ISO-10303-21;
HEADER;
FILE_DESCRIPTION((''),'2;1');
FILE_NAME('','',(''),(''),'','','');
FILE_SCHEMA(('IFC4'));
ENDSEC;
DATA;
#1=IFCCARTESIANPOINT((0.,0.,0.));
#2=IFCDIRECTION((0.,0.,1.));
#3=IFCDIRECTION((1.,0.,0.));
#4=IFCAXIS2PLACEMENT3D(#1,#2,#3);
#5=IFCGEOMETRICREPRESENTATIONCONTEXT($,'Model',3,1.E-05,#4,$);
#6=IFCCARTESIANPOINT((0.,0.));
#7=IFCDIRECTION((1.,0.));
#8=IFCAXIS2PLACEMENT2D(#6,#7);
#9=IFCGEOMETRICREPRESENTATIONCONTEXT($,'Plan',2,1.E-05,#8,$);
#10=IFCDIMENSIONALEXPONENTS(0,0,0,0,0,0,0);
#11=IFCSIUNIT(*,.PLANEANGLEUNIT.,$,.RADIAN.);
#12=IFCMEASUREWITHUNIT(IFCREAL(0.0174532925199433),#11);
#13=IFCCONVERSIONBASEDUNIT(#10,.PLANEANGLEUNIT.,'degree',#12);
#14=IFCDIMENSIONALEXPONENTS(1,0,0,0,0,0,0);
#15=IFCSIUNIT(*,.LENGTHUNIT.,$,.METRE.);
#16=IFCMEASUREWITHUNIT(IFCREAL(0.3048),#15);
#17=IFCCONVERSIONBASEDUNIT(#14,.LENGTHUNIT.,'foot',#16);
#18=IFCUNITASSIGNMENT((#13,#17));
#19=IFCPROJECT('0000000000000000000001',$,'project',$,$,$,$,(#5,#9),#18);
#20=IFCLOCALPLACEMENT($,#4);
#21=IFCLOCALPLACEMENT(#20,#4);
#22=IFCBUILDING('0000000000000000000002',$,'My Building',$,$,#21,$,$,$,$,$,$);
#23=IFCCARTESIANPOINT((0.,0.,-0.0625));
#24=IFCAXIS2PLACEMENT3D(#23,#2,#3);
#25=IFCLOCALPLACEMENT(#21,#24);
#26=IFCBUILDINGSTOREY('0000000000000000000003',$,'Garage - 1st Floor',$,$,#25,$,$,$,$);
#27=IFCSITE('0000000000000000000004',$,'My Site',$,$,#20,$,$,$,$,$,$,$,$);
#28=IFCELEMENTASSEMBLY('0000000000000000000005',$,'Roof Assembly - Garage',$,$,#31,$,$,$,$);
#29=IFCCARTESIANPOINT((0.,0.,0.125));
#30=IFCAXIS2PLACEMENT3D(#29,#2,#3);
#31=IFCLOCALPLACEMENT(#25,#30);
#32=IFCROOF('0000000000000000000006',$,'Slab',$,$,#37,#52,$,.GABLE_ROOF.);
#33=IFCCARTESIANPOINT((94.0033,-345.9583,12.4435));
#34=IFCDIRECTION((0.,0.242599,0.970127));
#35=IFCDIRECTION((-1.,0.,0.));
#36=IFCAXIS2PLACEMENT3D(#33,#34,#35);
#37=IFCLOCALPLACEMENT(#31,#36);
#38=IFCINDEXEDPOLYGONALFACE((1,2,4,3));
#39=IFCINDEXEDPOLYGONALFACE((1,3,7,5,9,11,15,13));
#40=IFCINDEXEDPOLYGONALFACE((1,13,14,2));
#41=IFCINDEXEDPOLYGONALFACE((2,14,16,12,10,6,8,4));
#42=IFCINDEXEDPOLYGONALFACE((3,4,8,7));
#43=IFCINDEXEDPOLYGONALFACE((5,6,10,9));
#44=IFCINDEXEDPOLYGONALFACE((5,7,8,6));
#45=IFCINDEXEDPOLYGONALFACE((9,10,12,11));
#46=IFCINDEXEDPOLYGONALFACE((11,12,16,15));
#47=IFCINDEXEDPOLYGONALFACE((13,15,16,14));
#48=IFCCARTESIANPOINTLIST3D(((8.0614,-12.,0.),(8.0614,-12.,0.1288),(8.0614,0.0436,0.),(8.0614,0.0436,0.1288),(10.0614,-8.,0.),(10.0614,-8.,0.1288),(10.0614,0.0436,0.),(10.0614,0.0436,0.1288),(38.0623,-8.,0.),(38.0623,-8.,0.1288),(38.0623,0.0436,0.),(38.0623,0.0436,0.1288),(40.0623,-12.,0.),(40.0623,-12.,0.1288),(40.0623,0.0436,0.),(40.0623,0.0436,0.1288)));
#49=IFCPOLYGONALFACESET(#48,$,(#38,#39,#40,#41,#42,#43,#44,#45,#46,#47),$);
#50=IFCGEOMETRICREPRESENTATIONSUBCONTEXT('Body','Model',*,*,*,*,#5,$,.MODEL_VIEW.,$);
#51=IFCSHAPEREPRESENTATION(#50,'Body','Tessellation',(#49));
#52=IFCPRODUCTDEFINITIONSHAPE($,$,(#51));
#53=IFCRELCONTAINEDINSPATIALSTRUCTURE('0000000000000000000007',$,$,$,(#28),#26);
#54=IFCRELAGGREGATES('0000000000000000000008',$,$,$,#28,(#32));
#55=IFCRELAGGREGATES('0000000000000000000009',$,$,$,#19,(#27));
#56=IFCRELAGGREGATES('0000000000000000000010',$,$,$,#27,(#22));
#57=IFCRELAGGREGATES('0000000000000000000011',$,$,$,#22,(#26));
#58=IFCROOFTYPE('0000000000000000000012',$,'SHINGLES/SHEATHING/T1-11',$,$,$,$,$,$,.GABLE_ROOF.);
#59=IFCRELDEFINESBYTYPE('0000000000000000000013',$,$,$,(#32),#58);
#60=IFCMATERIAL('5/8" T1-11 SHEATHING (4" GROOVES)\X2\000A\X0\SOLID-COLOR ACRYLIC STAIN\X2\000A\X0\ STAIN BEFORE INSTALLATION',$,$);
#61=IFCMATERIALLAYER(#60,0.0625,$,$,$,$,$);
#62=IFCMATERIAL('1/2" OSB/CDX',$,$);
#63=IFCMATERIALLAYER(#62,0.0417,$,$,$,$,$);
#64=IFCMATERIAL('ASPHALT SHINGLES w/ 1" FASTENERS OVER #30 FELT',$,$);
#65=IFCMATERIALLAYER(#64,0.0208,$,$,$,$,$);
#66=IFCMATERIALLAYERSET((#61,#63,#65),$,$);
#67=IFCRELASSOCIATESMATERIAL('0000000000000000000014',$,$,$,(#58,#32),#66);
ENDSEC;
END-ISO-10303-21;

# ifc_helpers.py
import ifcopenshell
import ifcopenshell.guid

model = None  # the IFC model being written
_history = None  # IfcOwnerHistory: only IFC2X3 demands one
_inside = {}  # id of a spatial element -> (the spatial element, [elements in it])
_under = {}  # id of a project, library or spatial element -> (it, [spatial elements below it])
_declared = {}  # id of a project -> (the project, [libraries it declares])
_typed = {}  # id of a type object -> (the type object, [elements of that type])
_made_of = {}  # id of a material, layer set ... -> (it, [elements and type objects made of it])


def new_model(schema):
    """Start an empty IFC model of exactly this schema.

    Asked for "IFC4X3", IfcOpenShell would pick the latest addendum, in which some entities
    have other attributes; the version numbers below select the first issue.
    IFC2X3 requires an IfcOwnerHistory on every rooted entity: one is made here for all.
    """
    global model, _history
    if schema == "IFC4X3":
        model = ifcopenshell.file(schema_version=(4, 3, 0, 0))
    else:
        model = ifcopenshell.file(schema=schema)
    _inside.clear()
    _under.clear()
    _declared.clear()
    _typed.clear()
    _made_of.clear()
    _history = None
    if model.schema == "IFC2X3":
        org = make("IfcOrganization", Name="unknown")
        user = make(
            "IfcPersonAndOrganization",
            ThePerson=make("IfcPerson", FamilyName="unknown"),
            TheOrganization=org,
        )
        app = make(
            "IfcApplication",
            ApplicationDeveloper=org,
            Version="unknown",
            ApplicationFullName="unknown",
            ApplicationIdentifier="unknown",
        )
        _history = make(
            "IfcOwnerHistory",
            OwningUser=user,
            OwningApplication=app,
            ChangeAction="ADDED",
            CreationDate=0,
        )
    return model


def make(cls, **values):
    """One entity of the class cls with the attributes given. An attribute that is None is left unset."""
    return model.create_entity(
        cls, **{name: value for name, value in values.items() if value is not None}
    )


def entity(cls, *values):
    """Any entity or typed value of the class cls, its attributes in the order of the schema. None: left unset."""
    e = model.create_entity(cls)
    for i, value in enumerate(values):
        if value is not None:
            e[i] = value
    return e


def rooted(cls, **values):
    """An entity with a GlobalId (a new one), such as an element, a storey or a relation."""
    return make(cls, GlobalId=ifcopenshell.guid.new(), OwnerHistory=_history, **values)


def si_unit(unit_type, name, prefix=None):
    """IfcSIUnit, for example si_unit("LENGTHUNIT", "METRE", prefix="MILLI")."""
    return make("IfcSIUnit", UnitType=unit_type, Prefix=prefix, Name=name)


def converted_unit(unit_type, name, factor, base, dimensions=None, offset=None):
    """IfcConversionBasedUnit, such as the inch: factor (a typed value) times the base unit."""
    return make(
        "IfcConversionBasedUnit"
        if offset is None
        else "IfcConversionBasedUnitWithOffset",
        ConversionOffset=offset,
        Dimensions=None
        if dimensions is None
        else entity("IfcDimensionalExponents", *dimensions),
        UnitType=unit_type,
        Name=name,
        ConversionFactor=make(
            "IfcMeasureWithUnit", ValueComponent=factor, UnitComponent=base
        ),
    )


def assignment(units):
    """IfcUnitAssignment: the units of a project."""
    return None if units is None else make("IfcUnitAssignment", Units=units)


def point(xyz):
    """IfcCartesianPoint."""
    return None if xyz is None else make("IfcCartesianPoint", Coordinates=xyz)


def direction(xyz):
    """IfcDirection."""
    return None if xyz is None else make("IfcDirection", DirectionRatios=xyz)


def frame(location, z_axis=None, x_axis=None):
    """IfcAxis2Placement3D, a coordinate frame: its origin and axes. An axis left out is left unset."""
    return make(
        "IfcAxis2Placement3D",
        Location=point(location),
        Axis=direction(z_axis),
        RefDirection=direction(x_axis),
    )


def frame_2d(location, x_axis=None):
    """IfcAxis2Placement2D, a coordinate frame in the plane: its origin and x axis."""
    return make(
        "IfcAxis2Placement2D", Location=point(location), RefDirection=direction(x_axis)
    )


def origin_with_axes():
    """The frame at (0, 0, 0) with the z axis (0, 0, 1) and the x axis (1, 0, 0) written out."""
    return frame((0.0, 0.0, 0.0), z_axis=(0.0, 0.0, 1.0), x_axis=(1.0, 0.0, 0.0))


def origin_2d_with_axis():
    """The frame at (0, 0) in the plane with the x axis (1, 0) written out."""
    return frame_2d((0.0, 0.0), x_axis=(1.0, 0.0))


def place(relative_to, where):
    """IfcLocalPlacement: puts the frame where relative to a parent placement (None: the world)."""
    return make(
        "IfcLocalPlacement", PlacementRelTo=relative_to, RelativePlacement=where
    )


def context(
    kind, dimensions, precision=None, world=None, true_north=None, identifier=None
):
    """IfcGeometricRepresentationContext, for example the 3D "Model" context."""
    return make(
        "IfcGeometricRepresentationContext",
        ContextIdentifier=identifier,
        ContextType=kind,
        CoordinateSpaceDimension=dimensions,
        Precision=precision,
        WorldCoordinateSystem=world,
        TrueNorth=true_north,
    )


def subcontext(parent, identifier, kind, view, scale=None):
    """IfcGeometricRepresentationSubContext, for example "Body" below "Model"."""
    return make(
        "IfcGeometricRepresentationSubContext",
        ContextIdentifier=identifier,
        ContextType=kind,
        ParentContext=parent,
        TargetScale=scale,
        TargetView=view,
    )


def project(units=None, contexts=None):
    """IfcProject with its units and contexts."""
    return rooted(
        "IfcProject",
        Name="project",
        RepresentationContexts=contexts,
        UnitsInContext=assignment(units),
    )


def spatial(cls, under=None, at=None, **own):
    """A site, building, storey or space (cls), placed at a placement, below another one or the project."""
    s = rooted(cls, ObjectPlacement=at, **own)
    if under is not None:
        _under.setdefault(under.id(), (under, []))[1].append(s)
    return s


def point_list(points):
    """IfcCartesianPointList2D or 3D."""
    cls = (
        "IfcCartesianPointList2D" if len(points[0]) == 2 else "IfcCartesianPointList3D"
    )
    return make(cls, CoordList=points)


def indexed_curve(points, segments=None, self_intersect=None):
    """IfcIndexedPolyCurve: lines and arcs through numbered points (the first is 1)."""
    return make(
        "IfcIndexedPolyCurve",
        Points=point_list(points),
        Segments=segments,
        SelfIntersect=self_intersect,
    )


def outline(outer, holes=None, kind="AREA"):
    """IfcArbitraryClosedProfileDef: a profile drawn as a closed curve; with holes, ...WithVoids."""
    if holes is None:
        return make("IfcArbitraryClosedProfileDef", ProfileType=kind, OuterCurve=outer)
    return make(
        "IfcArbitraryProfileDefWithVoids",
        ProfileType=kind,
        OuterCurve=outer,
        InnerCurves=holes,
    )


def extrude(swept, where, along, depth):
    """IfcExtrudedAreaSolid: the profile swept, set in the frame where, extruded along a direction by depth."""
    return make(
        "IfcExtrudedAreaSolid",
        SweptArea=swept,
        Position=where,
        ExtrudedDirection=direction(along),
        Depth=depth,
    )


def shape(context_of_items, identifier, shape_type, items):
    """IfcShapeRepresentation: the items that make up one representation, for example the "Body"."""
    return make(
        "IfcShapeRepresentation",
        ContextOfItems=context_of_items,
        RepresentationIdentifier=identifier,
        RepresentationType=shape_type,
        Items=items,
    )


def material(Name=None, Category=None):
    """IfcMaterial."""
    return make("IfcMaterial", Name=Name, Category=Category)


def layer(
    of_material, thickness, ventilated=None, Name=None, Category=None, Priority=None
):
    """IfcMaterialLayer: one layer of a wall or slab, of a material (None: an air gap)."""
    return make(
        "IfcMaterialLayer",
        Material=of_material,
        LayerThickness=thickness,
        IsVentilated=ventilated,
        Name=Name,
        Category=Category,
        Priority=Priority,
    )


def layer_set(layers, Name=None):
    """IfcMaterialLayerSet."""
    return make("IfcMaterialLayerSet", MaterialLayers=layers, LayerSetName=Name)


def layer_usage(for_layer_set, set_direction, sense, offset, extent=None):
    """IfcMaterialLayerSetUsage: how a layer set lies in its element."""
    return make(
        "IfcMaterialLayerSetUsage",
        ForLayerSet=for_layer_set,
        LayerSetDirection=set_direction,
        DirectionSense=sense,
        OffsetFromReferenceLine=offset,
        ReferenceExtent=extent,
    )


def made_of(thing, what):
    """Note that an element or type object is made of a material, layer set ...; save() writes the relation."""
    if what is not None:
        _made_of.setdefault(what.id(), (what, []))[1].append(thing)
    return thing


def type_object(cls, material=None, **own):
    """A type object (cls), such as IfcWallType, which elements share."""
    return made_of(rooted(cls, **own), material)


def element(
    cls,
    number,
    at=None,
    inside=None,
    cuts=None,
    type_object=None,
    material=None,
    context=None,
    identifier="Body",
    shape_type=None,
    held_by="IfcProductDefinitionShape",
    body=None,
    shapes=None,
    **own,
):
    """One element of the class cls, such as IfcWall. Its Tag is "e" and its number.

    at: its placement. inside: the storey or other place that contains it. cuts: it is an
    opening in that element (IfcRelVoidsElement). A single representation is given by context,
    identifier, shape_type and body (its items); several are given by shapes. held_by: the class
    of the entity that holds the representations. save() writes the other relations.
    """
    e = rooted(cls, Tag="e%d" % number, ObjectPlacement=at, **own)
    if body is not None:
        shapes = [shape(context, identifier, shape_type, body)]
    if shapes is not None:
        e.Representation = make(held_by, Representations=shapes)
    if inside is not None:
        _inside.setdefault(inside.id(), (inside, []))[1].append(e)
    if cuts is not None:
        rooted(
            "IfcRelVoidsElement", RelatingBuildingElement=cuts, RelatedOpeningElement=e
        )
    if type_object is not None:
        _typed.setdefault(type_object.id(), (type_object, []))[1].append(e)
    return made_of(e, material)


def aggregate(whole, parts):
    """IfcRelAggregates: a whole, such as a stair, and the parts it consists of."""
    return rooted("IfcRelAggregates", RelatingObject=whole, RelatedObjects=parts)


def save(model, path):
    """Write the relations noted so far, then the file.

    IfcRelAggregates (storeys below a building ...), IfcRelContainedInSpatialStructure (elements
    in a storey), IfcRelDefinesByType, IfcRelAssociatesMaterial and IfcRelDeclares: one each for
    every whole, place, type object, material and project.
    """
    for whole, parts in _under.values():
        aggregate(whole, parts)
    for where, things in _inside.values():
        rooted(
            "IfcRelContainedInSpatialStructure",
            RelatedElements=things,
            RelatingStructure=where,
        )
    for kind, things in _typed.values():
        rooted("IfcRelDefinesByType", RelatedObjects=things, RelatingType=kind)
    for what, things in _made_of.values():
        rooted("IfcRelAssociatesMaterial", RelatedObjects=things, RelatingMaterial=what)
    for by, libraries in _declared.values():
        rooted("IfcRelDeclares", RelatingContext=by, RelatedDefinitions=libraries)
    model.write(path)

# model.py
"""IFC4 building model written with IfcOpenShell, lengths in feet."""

from ifc_helpers import new_model, entity, si_unit, converted_unit, frame, origin_with_axes, origin_2d_with_axis, place, context, subcontext, project, spatial, indexed_curve, outline, extrude, material, layer, layer_set, layer_usage, type_object, element, aggregate, save


model = new_model("IFC4")

# Units and contexts
model_context = context("Model", 3, precision=1e-05, world=origin_with_axes())
plan_context = context("Plan", 2, precision=1e-05, world=origin_2d_with_axis())
body_context = subcontext(model_context, "Body", "Model", "MODEL_VIEW")
ifc_project = project(units=[converted_unit("PLANEANGLEUNIT", "degree", entity("IfcReal", 0.0174532925199433), si_unit("PLANEANGLEUNIT", "RADIAN"), dimensions=[0, 0, 0, 0, 0, 0, 0]), converted_unit("LENGTHUNIT", "foot", entity("IfcReal", 0.3048), si_unit("LENGTHUNIT", "METRE"), dimensions=[1, 0, 0, 0, 0, 0, 0])], contexts=[model_context, plan_context])

# Site, building, storey
site_placement = place(None, origin_with_axes())
site = spatial("IfcSite", under=ifc_project, at=site_placement, Name="My Site")
building_placement = place(site_placement, origin_with_axes())
building = spatial("IfcBuilding", under=site, at=building_placement, Name="My Building")
storey_placement = place(building_placement, frame((0.0, 0.0, -0.0625), z_axis=(0.0, 0.0, 1.0), x_axis=(1.0, 0.0, 0.0)))
storey = spatial("IfcBuildingStorey", under=building, at=storey_placement, Name="Garage - 1st Floor")

# Element assembly, roof
assembly_1_placement = place(storey_placement, frame((0.0, 0.0, 0.125), z_axis=(0.0, 0.0, 1.0), x_axis=(1.0, 0.0, 0.0)))
assembly_1 = element("IfcElementAssembly", 1, at=assembly_1_placement, inside=storey, Name="Roof Assembly - Garage")
ifc_material_1 = material(Name="5/8\" T1-11 SHEATHING (4\" GROOVES)\nSOLID-COLOR ACRYLIC STAIN\n STAIN BEFORE INSTALLATION")
ifc_layer_1 = layer(ifc_material_1, 0.0625)
ifc_material_2 = material(Name="1/2\" OSB/CDX")
ifc_layer_2 = layer(ifc_material_2, 0.0417)
ifc_material_3 = material(Name="ASPHALT SHINGLES w/ 1\" FASTENERS OVER #30 FELT")
ifc_layer_3 = layer(ifc_material_3, 0.0208)
ifc_layer_set_1 = layer_set([ifc_layer_1, ifc_layer_2, ifc_layer_3])
ifc_layer_usage_1 = layer_usage(ifc_layer_set_1, "AXIS3", "POSITIVE", 0.0)
roof_type = type_object("IfcRoofType", Name="SHINGLES/SHEATHING/T1-11", PredefinedType="GABLE_ROOF", material=ifc_layer_set_1)
roof_placement = place(assembly_1_placement, frame((94.0033, -345.9583, 12.4435), z_axis=(0.0, 0.242599, 0.970127), x_axis=(-1.0, 0.0, 0.0)))
roof = element("IfcRoof", 2, at=roof_placement, type_object=roof_type, material=ifc_layer_usage_1, Name="Slab", PredefinedType="GABLE_ROOF", context=body_context, shape_type="SweptSolid", body=[
    extrude(outline(indexed_curve([(40.0623, -12.0), (8.0614, -12.0), (8.0614, 0.0436), (10.0614, 0.0436), (10.0614, -8.0), (38.0623, -8.0), (38.0623, 0.0436), (40.0623, 0.0436), (40.0623, -12.0)])), None, (0.0, 0.0, 1.0), 0.1288),
])
aggregate(assembly_1, [roof])

save(model, "model.ifc")
